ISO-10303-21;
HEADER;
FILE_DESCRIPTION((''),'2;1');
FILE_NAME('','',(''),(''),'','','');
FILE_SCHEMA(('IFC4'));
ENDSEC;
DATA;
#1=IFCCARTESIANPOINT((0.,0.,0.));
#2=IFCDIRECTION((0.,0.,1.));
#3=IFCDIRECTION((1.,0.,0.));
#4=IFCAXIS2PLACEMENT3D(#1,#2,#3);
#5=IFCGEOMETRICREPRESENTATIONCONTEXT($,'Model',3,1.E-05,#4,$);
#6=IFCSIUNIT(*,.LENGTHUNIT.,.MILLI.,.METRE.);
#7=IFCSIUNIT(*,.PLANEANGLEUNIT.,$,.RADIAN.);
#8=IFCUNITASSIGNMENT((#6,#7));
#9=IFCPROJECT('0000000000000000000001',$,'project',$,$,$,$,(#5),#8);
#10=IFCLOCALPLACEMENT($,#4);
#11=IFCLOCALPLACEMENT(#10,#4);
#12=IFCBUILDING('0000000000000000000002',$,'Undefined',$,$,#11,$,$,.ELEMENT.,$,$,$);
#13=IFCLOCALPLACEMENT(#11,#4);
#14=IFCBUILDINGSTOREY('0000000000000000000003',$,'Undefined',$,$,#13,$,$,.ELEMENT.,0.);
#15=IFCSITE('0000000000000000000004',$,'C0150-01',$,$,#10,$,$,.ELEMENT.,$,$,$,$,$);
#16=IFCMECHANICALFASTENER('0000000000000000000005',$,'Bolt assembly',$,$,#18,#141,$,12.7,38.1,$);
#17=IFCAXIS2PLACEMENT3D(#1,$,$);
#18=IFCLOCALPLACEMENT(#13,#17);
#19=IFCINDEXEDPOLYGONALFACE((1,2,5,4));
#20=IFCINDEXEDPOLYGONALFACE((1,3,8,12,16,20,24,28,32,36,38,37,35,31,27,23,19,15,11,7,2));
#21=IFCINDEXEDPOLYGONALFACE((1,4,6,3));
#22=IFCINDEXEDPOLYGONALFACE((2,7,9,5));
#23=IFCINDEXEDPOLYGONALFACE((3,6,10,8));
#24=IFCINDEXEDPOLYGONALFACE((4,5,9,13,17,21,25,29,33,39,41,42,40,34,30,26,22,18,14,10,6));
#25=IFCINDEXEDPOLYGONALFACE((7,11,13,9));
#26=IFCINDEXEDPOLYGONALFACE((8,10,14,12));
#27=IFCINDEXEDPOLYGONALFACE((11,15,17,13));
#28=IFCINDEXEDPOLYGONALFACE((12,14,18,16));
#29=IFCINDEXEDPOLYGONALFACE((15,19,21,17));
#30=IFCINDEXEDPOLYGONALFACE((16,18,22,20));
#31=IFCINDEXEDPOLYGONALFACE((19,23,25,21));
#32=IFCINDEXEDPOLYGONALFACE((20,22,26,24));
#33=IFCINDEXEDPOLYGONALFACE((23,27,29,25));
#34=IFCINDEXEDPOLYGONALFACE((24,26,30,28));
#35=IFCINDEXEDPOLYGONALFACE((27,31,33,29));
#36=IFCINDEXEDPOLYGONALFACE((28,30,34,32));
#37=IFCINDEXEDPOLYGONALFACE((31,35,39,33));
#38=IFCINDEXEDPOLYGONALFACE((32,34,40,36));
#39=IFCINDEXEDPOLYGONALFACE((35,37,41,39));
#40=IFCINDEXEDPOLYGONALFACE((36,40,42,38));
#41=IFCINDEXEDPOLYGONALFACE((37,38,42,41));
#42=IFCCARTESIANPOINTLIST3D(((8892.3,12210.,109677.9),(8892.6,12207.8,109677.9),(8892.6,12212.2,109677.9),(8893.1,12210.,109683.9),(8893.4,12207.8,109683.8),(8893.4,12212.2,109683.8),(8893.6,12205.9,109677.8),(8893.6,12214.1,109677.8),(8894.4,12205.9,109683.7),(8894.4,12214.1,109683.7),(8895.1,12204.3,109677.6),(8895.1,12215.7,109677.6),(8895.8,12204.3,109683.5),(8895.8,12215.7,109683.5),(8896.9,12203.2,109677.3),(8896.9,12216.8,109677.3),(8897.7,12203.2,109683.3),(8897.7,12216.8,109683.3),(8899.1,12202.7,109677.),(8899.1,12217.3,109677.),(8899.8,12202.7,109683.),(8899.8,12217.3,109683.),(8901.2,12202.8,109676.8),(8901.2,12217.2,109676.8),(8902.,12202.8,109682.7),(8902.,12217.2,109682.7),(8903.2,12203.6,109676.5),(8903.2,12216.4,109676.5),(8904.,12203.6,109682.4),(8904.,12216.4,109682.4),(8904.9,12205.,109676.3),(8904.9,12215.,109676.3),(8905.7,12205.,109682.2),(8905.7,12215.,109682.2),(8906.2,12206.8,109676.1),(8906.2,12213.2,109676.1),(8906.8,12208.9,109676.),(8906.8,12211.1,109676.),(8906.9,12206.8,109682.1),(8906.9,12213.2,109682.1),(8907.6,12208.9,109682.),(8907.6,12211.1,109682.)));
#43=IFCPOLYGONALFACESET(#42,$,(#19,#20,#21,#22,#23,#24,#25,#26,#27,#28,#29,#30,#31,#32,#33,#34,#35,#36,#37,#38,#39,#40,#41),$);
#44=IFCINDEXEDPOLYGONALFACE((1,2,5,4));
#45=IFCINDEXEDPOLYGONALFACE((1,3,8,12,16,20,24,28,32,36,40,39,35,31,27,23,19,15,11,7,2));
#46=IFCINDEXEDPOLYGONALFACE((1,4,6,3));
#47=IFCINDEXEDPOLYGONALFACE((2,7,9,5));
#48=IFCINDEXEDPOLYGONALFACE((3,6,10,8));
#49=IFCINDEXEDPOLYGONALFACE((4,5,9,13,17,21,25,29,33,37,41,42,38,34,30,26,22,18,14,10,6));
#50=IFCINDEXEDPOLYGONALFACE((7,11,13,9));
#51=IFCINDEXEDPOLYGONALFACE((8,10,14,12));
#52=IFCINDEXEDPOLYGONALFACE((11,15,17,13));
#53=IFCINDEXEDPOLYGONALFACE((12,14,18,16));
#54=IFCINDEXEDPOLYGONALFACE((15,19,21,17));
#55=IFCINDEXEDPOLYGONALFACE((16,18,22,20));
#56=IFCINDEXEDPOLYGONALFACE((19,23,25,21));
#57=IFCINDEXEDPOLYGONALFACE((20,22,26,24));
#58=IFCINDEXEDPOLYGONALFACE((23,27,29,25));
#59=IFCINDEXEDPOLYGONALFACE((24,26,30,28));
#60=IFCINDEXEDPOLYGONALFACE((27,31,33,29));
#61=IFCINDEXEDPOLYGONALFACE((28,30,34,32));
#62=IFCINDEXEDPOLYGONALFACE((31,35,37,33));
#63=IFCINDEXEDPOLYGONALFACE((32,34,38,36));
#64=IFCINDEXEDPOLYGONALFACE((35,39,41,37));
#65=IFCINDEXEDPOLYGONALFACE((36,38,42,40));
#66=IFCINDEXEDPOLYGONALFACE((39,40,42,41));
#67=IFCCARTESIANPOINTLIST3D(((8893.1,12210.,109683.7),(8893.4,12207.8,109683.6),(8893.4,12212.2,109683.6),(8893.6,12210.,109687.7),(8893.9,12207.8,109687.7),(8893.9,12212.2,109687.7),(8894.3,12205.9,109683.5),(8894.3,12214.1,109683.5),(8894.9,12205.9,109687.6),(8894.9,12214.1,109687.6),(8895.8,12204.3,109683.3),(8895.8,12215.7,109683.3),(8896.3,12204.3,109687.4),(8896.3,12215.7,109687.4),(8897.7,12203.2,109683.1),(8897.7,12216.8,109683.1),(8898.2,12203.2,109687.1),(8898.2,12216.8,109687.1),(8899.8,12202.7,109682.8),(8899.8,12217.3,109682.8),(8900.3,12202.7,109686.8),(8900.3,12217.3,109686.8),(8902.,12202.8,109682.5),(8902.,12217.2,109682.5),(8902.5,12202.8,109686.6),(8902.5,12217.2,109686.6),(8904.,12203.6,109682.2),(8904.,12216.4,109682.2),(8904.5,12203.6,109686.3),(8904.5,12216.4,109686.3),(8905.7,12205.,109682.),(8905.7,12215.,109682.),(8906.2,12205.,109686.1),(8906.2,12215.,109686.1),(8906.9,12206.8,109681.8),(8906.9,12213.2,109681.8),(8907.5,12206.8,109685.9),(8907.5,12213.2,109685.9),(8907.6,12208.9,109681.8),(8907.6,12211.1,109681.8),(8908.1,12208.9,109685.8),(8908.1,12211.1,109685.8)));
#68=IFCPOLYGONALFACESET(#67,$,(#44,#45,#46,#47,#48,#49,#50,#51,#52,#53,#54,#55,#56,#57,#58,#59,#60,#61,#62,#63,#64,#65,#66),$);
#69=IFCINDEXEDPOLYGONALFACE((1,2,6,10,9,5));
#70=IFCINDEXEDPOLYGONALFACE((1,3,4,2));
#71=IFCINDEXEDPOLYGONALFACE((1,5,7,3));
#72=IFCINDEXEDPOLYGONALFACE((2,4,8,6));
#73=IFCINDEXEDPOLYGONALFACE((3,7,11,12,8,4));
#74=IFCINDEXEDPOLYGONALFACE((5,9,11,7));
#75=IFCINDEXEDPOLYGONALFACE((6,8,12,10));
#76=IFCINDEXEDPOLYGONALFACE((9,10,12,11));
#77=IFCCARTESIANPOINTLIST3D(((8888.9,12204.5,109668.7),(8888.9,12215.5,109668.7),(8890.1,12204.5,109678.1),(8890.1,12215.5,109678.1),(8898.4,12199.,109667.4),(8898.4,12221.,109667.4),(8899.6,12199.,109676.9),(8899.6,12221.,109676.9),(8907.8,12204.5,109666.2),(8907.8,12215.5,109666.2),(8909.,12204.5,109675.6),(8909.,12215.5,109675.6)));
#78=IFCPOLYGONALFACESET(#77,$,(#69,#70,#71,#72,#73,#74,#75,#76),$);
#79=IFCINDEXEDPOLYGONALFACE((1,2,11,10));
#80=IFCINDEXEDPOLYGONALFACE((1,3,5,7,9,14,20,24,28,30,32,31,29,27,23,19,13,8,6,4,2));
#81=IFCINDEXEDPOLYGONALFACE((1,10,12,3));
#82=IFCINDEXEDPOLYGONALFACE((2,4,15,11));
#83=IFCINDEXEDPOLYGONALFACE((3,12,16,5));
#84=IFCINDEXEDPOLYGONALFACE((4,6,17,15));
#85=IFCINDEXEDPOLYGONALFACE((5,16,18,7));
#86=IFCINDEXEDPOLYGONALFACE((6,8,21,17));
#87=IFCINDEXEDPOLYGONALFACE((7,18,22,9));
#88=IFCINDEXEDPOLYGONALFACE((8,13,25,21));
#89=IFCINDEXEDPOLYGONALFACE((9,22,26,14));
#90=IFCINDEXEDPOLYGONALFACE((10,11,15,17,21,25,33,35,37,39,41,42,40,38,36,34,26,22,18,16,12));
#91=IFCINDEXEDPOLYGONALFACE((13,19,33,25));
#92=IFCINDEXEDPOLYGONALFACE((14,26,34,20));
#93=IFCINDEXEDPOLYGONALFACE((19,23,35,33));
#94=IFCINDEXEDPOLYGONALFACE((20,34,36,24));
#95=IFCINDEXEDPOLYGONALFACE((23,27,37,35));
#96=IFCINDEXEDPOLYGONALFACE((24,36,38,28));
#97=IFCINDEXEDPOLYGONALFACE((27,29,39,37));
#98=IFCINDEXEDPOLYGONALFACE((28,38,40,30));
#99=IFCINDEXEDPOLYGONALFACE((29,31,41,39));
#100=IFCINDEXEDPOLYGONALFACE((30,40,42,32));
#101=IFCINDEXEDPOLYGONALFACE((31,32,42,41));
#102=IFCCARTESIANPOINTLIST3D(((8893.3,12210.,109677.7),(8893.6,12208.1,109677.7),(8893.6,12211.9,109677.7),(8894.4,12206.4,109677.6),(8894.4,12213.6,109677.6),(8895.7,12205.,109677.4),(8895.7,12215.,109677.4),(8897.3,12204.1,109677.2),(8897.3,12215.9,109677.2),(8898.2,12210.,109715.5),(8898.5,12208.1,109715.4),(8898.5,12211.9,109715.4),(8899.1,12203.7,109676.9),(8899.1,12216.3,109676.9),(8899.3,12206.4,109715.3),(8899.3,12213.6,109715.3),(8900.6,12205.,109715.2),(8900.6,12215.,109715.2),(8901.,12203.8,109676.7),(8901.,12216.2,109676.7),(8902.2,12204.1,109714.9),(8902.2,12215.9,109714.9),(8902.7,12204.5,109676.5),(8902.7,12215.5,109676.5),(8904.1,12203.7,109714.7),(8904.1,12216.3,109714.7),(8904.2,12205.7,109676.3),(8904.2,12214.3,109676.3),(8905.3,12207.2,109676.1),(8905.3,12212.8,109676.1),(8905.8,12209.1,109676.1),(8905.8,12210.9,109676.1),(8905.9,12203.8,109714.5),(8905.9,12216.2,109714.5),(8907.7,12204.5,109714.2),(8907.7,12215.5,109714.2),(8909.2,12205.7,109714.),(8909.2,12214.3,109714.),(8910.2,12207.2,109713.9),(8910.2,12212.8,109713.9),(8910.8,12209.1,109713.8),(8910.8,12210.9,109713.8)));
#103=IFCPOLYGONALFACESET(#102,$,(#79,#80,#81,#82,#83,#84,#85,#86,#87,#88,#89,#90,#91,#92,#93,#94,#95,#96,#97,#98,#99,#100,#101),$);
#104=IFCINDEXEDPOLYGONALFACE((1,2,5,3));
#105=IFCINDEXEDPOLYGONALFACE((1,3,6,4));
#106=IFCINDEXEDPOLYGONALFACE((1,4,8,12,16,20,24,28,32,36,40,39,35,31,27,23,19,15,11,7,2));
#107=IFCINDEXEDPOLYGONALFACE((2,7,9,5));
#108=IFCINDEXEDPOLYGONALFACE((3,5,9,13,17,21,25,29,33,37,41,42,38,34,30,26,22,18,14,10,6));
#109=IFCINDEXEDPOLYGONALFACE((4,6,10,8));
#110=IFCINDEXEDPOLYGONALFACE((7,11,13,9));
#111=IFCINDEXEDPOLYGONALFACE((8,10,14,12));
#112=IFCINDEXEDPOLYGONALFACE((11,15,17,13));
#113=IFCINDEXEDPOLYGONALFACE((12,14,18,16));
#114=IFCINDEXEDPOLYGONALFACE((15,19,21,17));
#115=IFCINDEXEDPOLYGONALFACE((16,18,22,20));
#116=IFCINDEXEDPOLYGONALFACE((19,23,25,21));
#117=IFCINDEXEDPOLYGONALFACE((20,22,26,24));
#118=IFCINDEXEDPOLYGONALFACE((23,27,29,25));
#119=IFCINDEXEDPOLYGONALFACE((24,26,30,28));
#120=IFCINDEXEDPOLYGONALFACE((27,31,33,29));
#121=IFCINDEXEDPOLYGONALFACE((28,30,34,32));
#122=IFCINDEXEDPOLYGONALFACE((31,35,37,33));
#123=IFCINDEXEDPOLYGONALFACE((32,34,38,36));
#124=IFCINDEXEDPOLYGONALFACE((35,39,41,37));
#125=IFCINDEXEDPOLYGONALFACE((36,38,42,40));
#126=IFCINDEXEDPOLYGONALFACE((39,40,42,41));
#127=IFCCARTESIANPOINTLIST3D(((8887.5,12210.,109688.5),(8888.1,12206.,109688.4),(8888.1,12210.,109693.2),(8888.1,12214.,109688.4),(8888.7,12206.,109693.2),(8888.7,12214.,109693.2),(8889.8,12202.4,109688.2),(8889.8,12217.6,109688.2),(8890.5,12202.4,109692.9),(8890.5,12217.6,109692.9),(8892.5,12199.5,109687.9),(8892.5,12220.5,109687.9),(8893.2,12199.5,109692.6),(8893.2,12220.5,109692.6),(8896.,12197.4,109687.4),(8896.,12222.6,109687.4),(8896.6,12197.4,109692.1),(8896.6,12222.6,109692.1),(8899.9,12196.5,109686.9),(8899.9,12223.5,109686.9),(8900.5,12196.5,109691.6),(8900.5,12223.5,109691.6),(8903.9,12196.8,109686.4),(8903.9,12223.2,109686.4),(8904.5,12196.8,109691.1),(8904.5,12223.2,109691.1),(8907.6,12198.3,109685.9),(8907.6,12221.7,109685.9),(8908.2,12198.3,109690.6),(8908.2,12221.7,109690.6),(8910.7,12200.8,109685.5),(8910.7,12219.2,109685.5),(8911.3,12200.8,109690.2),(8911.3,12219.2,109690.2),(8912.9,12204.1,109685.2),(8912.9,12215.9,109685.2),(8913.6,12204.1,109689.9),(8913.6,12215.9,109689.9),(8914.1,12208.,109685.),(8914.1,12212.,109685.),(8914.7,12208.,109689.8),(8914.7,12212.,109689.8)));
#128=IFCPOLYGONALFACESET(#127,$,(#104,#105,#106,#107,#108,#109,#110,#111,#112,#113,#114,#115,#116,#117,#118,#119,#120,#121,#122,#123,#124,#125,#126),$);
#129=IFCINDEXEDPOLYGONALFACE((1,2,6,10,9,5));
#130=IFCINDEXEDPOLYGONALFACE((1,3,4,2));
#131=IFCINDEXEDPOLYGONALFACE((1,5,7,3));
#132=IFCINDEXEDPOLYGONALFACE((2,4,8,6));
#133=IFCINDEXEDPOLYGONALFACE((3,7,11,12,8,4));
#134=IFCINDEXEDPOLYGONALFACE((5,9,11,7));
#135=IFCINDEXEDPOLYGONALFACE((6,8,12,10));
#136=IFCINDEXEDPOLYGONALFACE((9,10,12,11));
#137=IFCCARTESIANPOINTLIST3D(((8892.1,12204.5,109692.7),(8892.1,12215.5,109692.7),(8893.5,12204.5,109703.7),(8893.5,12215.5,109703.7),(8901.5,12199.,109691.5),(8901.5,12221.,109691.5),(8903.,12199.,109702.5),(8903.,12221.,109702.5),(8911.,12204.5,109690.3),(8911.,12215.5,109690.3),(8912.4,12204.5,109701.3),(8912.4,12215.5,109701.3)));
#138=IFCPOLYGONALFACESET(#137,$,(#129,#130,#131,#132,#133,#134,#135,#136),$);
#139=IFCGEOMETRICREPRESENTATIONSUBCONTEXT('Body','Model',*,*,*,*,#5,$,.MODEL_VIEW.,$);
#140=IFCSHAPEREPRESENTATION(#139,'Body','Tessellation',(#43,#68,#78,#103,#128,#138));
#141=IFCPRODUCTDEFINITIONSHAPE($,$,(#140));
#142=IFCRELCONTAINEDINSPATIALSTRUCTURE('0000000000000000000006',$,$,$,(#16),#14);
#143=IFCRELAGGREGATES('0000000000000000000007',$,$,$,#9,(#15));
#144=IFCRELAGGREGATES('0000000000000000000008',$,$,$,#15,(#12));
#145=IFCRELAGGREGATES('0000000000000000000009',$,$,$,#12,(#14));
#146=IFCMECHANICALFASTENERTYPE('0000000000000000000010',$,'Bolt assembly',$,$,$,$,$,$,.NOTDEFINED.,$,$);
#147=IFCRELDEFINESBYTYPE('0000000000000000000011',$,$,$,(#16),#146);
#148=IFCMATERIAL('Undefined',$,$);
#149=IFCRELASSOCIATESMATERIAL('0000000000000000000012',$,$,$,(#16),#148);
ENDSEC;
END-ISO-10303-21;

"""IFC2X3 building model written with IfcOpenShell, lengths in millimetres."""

from ifc_helpers import new_model, si_unit, frame, origin_with_axes, origin_2d_with_axis, place, context, subcontext, project, spatial, polyline, circle, outline, extrude, source, transform, mapped, material, type_object, element, save


model = new_model("IFC2X3")

# Units and contexts
model_context = context("Model", 3, precision=1e-05, world=origin_with_axes())
body_context = subcontext(model_context, "Body", "Model", "MODEL_VIEW")
ifc_project = project(units=[si_unit("LENGTHUNIT", "METRE", prefix="MILLI"), si_unit("PLANEANGLEUNIT", "RADIAN")], contexts=[model_context])

# Site, building, storey
site_placement = place(None, origin_with_axes())
site = spatial("IfcSite", under=ifc_project, at=site_placement, Name="C0150-01", CompositionType="ELEMENT")
building_placement = place(site_placement, origin_with_axes())
building = spatial("IfcBuilding", under=site, at=building_placement, Name="Undefined", CompositionType="ELEMENT")
storey_placement = place(building_placement, origin_with_axes())
storey = spatial("IfcBuildingStorey", under=building, at=storey_placement, Name="Undefined", CompositionType="ELEMENT", Elevation=0.0)

# Mechanical fastener
ifc_material_1 = material(Name="Undefined")
mechanical_fastener_type = type_object("IfcMechanicalFastenerType", Name="Bolt assembly")
shared_shape_1 = source(origin_with_axes(), body_context, "Body", "SweptSolid", [
    extrude(circle(Radius=7.3, at=origin_2d_with_axis()), frame((0.0, -9.9, 0.0), z_axis=(0.0, 1.0, 0.0), x_axis=(1.0, 0.0, 0.0)), (0.0, 0.0, 1.0), 6.0),
    extrude(circle(Radius=7.3, at=origin_2d_with_axis()), frame((0.0, -4.1, 0.0), z_axis=(0.0, 1.0, 0.0), x_axis=(1.0, 0.0, 0.0)), (0.0, 0.0, 1.0), 4.1),
    extrude(outline(polyline([(9.5, -5.5), (9.5, 5.5), (0.0, 11.0), (-9.5, 5.5), (-9.5, -5.5), (0.0, -11.0), (9.5, -5.5)])), frame((0.0, -19.5, 0.0), z_axis=(0.0, 1.0, 0.0), x_axis=(1.0, 0.0, 0.0)), (0.0, 0.0, 1.0), 9.5),
    extrude(circle(Radius=6.3, at=origin_2d_with_axis()), frame((0.0, -10.0, 0.0), z_axis=(0.0, 1.0, 0.0), x_axis=(1.0, 0.0, 0.0)), (0.0, 0.0, 1.0), 38.1),
    extrude(circle(Radius=13.5, at=origin_2d_with_axis()), frame((0.0, 0.0, 0.0), z_axis=(0.0, 1.0, 0.0), x_axis=(1.0, 0.0, 0.0)), (0.0, 0.0, 1.0), 4.8),
    extrude(outline(polyline([(9.5, -5.5), (9.5, 5.5), (0.0, 11.0), (-9.5, 5.5), (-9.5, -5.5), (0.0, -11.0), (9.5, -5.5)])), frame((0.0, 4.8, 0.0), z_axis=(0.0, 1.0, 0.0), x_axis=(1.0, 0.0, 0.0)), (0.0, 0.0, 1.0), 11.1),
])
for number, where, z_axis, x_axis, name in (
    (1, (8900.9, 12210.0, 109686.8), (0.0, 1.0, 0.0), (-0.991507, 0.0, 0.130054), "Bolt assembly"),
):
    element("IfcMechanicalFastener", number, at=place(storey_placement, frame(where, z_axis=z_axis, x_axis=x_axis)), inside=storey, type_object=mechanical_fastener_type, material=ifc_material_1, Name=name, NominalDiameter=12.7, NominalLength=38.1, context=body_context, shape_type="MappedRepresentation", body=[
        mapped(shared_shape_1, transform((0.0, 0.0, 0.0))),
    ])

save(model, "model.ifc")
